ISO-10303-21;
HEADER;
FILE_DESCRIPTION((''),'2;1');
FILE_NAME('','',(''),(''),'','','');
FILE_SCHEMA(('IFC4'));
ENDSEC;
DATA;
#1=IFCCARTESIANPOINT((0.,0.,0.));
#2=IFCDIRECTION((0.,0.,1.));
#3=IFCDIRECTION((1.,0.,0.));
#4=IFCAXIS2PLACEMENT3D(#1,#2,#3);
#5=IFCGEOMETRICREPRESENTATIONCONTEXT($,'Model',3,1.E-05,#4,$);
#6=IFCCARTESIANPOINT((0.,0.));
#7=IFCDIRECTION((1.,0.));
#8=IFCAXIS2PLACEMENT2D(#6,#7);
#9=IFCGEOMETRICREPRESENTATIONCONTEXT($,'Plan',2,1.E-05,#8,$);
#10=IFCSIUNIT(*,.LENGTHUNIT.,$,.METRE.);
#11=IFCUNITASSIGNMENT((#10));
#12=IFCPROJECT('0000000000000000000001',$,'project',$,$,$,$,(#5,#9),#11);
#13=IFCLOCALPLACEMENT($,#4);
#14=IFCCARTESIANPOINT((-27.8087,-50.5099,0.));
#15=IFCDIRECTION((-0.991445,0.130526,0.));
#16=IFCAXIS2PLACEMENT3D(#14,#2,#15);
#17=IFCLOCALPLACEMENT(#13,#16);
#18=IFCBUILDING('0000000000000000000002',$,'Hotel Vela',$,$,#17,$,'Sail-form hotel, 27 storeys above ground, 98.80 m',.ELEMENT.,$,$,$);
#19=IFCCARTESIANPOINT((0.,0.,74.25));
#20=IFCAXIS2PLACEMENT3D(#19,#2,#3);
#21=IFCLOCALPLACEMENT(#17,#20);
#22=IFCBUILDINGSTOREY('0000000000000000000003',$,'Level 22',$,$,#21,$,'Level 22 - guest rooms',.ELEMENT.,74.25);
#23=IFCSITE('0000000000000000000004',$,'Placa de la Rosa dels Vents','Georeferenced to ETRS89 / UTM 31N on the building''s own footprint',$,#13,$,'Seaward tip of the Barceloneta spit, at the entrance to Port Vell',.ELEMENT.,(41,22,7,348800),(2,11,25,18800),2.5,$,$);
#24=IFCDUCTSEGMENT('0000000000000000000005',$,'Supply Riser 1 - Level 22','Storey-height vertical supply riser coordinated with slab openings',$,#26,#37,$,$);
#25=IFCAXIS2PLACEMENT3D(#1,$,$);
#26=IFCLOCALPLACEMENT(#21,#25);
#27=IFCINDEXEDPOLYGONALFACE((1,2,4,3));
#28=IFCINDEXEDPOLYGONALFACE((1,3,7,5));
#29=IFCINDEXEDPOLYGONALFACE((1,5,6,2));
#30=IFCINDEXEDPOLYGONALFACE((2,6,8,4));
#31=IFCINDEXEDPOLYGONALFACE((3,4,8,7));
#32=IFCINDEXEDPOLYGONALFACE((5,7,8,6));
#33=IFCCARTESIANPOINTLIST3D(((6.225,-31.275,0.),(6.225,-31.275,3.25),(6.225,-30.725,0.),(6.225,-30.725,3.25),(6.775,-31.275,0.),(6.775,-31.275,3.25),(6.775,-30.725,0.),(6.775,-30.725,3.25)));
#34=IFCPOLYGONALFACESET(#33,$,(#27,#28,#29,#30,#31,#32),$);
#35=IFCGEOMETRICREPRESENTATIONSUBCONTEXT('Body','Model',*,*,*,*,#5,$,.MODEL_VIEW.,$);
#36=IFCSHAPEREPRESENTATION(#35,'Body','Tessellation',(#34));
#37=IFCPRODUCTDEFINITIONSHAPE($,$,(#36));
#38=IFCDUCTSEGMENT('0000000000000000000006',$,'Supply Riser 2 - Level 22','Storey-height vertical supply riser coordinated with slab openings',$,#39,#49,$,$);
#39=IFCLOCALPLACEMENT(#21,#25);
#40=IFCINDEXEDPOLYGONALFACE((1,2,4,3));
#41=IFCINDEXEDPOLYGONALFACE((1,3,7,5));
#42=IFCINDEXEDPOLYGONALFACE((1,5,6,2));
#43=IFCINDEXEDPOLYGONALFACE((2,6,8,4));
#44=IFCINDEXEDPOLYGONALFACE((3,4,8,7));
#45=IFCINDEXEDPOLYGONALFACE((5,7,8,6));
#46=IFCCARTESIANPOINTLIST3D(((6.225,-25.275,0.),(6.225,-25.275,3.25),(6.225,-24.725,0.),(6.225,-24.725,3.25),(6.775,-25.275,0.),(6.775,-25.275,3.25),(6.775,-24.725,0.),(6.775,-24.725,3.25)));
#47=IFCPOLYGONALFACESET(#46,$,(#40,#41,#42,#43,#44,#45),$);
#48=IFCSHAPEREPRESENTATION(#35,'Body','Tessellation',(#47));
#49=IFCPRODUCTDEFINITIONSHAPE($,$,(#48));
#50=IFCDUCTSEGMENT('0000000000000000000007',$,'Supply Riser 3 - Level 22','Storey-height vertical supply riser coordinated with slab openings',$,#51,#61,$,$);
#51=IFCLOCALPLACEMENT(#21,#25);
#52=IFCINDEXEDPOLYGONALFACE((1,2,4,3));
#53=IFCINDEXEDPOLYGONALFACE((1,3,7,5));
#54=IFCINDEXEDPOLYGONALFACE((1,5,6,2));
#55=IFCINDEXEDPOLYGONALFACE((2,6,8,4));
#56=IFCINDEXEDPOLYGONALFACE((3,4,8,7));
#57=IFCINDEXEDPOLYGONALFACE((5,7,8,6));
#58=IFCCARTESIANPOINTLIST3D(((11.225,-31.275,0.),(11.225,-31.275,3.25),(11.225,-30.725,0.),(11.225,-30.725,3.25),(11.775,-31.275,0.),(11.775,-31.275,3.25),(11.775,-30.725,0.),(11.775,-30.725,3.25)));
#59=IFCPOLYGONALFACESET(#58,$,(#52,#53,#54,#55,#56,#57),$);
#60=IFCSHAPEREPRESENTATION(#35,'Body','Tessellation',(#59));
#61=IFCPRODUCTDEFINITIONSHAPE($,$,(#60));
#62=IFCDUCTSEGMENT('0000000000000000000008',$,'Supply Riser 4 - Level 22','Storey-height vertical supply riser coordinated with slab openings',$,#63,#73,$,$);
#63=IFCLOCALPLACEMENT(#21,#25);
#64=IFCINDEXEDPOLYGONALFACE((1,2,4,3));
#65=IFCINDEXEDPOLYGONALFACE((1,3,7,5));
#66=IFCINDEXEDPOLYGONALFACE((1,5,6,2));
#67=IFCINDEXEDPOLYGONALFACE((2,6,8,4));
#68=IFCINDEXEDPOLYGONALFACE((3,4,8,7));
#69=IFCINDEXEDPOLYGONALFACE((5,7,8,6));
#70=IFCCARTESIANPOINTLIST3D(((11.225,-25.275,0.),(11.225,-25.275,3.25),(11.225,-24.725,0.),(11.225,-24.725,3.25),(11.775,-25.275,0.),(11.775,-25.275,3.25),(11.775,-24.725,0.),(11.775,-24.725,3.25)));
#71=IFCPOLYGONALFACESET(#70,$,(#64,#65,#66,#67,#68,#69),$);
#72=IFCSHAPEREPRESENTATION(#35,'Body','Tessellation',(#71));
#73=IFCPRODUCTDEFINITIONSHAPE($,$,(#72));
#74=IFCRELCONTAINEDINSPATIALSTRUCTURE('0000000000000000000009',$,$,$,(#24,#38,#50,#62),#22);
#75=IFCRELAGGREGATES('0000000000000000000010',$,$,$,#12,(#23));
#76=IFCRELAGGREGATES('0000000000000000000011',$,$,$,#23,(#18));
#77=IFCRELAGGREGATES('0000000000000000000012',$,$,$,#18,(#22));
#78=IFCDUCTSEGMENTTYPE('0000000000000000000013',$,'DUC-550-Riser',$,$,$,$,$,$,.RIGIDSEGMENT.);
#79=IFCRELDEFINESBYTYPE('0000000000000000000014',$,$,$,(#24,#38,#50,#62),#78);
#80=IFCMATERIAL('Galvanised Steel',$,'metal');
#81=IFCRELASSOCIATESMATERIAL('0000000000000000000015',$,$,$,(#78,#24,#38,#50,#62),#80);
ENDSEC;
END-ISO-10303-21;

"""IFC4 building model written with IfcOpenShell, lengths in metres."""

from ifc_helpers import new_model, si_unit, frame, origin_with_axes, origin_2d_with_axis, place, context, subcontext, project, spatial, line, indexed_curve, outline, extrude, material, type_object, element, save


model = new_model("IFC4")

# Units and contexts
model_context = context("Model", 3, precision=1e-05, world=origin_with_axes())
plan_context = context("Plan", 2, precision=1e-05, world=origin_2d_with_axis())
body_context = subcontext(model_context, "Body", "Model", "MODEL_VIEW")
ifc_project = project(units=[si_unit("LENGTHUNIT", "METRE")], contexts=[model_context, plan_context])

# Site, building, storey
site_placement = place(None, origin_with_axes())
site = spatial("IfcSite", under=ifc_project, at=site_placement, Name="Placa de la Rosa dels Vents", Description="Georeferenced to ETRS89 / UTM 31N on the building's own footprint", LongName="Seaward tip of the Barceloneta spit, at the entrance to Port Vell", CompositionType="ELEMENT", RefLatitude=(41, 22, 7, 348800), RefLongitude=(2, 11, 25, 18800), RefElevation=2.5)
building_placement = place(site_placement, frame((-27.8087, -50.5099, 0.0), z_axis=(0.0, 0.0, 1.0), x_axis=(-0.991445, 0.130526, 0.0)))
building = spatial("IfcBuilding", under=site, at=building_placement, Name="Hotel Vela", LongName="Sail-form hotel, 27 storeys above ground, 98.80 m", CompositionType="ELEMENT")
storey_placement = place(building_placement, frame((0.0, 0.0, 74.25), z_axis=(0.0, 0.0, 1.0), x_axis=(1.0, 0.0, 0.0)))
storey = spatial("IfcBuildingStorey", under=building, at=storey_placement, Name="Level 22", LongName="Level 22 - guest rooms", CompositionType="ELEMENT", Elevation=74.25)

# Duct segments
ifc_material = material(Name="Galvanised Steel", Category="metal")
duct_segment_type = type_object("IfcDuctSegmentType", Name="DUC-550-Riser", PredefinedType="RIGIDSEGMENT", material=ifc_material)
for number, where, z_axis, x_axis, name in (
    (1, (6.225, -31.275, 0.0), (0.0, 0.0, 1.0), (1.0, 0.0, 0.0), "Supply Riser 1 - Level 22"),
    (2, (6.225, -25.275, 0.0), (0.0, 0.0, 1.0), (1.0, 0.0, 0.0), "Supply Riser 2 - Level 22"),
    (3, (11.225, -31.275, 0.0), (0.0, 0.0, 1.0), (1.0, 0.0, 0.0), "Supply Riser 3 - Level 22"),
    (4, (11.225, -25.275, 0.0), (0.0, 0.0, 1.0), (1.0, 0.0, 0.0), "Supply Riser 4 - Level 22"),
):
    element("IfcDuctSegment", number, at=place(storey_placement, frame(where, z_axis=z_axis, x_axis=x_axis)), inside=storey, type_object=duct_segment_type, material=ifc_material, Name=name, Description="Storey-height vertical supply riser coordinated with slab openings", context=body_context, shape_type="SweptSolid", body=[
        extrude(outline(indexed_curve([(0.0, 0.0), (0.55, 0.0), (0.55, 0.55), (0.0, 0.55)], segments=[line(1, 2, 3, 4, 1)])), origin_with_axes(), (0.0, 0.0, 1.0), 3.25),
    ])

save(model, "model.ifc")
